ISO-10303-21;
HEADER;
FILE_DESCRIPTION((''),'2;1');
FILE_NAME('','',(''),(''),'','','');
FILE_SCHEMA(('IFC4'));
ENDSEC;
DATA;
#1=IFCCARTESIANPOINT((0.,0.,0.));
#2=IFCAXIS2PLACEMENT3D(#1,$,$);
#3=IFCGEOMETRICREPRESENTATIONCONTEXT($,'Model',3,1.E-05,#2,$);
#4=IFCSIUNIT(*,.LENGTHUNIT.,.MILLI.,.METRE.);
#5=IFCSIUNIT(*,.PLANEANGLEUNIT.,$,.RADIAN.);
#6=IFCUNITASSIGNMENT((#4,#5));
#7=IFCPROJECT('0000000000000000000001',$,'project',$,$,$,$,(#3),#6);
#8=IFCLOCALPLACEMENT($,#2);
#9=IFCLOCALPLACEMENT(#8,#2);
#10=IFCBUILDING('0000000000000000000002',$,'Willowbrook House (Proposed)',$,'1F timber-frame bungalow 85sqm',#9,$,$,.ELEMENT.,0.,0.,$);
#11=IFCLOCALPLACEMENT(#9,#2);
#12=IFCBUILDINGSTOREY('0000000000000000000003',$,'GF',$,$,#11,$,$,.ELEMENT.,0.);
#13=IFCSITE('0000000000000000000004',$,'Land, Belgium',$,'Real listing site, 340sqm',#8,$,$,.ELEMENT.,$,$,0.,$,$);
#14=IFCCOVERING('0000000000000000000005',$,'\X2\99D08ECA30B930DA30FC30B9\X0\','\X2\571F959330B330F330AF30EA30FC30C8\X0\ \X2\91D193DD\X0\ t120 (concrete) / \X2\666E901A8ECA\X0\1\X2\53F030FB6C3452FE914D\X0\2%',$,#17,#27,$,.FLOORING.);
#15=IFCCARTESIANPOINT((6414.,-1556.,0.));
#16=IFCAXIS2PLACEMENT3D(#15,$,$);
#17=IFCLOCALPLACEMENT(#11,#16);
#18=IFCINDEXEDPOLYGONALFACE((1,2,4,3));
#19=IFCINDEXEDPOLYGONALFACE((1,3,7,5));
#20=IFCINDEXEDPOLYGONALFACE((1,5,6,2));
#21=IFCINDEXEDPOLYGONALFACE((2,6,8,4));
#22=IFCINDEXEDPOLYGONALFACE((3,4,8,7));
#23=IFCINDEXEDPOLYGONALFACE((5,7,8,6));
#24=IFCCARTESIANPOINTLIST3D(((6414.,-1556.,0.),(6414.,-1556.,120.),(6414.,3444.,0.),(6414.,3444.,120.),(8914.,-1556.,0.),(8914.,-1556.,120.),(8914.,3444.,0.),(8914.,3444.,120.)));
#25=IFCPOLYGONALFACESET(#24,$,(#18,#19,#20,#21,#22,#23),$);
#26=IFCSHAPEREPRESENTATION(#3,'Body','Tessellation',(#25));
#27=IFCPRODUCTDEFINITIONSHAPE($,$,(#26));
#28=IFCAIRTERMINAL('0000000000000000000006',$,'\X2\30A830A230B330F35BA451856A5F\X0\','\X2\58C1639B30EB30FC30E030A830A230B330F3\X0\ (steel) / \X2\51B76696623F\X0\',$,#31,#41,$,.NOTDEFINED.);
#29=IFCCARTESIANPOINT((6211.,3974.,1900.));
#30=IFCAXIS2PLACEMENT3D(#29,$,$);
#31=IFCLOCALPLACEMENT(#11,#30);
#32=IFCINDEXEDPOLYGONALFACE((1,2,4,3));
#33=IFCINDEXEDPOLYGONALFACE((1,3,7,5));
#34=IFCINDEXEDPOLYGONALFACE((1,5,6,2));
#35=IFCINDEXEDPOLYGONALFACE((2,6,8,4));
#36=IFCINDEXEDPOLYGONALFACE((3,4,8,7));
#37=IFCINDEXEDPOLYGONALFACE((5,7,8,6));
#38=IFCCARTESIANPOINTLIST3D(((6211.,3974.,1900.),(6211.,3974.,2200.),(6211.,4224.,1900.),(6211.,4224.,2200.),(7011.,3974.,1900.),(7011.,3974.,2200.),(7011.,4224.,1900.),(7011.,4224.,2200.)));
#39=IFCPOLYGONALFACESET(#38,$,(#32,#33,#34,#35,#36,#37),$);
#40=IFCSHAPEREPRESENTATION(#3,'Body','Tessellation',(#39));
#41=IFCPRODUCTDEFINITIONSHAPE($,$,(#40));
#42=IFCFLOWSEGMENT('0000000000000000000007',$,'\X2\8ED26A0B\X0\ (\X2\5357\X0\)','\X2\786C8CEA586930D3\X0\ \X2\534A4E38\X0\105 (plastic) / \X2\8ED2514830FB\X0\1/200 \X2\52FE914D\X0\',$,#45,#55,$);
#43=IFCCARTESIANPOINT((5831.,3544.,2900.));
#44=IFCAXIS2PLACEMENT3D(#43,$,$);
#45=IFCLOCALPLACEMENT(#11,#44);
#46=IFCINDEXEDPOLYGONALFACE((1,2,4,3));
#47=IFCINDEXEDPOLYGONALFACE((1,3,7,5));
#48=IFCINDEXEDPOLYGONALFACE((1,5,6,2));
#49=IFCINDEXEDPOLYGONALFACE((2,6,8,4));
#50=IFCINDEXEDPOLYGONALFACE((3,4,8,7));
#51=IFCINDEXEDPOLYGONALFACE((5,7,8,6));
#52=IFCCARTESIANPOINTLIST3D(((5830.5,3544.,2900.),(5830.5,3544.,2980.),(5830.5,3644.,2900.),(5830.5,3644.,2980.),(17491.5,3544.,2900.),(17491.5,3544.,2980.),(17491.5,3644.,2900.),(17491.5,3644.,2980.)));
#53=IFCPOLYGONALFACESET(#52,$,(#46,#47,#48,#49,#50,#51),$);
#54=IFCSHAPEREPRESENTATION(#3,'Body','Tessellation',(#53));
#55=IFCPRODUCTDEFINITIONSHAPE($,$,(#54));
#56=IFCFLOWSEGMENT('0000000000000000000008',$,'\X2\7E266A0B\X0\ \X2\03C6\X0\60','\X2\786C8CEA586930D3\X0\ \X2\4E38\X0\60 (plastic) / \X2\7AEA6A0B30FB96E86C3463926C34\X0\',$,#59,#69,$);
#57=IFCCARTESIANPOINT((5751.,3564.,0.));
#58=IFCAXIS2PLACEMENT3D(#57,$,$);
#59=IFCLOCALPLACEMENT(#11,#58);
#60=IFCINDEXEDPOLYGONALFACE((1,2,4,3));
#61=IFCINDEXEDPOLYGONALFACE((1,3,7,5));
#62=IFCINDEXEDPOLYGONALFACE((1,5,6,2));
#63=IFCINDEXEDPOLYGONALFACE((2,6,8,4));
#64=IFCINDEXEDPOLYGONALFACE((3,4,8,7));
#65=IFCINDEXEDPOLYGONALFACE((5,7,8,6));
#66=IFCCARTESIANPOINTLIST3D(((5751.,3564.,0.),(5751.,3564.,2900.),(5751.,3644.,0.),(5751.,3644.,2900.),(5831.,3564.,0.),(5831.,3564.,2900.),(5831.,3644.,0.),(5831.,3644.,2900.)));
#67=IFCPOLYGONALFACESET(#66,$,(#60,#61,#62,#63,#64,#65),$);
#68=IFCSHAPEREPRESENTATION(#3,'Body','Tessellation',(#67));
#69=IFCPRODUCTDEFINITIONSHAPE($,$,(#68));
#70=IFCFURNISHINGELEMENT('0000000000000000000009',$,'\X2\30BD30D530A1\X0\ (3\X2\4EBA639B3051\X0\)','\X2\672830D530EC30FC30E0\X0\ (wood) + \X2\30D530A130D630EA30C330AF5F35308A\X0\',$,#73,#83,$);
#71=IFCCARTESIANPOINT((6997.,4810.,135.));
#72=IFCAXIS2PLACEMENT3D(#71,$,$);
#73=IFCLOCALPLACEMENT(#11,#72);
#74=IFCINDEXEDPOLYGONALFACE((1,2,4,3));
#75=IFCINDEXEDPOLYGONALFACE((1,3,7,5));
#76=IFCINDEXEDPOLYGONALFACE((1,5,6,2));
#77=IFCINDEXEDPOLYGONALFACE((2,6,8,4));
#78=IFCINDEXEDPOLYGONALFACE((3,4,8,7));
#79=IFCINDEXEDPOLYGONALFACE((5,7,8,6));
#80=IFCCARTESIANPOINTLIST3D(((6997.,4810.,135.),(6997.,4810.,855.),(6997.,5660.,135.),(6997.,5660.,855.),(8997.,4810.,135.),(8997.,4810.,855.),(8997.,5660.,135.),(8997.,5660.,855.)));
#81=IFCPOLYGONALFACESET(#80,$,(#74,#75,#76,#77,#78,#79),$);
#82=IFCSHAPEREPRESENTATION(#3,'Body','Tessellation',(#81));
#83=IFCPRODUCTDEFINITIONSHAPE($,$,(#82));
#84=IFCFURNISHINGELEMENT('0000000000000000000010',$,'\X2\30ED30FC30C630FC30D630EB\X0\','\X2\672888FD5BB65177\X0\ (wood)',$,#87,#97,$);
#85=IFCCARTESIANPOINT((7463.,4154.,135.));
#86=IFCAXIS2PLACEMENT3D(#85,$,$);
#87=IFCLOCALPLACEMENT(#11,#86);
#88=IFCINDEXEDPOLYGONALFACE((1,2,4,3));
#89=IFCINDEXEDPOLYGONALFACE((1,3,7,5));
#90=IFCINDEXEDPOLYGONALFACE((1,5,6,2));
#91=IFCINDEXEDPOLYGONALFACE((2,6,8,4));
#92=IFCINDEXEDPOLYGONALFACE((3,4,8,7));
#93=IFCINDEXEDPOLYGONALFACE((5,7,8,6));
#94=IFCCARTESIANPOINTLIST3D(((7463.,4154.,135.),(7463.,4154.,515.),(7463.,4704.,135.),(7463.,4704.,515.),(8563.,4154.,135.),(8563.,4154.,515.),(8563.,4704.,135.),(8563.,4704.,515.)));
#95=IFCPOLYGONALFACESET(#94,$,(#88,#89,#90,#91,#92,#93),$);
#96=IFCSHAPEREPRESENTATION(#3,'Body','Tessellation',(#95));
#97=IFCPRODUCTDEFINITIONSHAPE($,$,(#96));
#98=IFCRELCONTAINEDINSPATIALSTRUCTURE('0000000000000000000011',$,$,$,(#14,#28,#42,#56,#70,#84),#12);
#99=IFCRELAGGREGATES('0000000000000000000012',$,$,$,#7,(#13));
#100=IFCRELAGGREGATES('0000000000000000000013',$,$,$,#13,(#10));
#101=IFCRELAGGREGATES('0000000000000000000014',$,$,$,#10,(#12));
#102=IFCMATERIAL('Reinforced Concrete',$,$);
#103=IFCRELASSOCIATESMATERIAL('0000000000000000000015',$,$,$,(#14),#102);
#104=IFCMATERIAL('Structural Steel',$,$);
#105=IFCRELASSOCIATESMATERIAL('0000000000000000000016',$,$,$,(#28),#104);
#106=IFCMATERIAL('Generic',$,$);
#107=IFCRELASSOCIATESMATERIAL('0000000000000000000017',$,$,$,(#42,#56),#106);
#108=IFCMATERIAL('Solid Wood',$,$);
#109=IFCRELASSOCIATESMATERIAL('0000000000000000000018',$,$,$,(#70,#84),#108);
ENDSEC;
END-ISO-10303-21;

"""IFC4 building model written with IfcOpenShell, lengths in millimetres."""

from ifc_helpers import new_model, si_unit, frame, frame_2d, origin, place, context, project, spatial, rectangle, extrude, material, element, save


model = new_model("IFC4")

# Units and contexts
model_context = context("Model", 3, precision=1e-05, world=origin())
ifc_project = project(units=[si_unit("LENGTHUNIT", "METRE", prefix="MILLI"), si_unit("PLANEANGLEUNIT", "RADIAN")], contexts=[model_context])

# Site, building, storey
site_placement = place(None, origin())
site = spatial("IfcSite", under=ifc_project, at=site_placement, Name="Land, Belgium", ObjectType="Real listing site, 340sqm", CompositionType="ELEMENT", RefElevation=0.0)
building_placement = place(site_placement, origin())
building = spatial("IfcBuilding", under=site, at=building_placement, Name="Willowbrook House (Proposed)", ObjectType="1F timber-frame bungalow 85sqm", CompositionType="ELEMENT", ElevationOfRefHeight=0.0, ElevationOfTerrain=0.0)
storey_placement = place(building_placement, origin())
storey = spatial("IfcBuildingStorey", under=building, at=storey_placement, Name="GF", CompositionType="ELEMENT", Elevation=0.0)

# Shared definitions
ifc_material_1 = material(Name="Solid Wood")

# Shared definitions
ifc_material_2 = material(Name="Reinforced Concrete")

# Shared definitions
ifc_material_3 = material(Name="Structural Steel")

# Covering
ifc_material_4 = material(Name="Generic")
covering_1_placement = place(storey_placement, frame((6414.0, -1556.0, 0.0)))
element("IfcCovering", 1, at=covering_1_placement, inside=storey, material=ifc_material_2, Name="駐車スペース", Description="土間コンクリート 金鏝 t120 (concrete) / 普通車1台・水勾配2%", PredefinedType="FLOORING", context=model_context, shape_type="SweptSolid", body=[
    extrude(rectangle(XDim=2500.0, YDim=5000.0, at=frame_2d((1250.0, 2500.0))), frame((6414.0, -1556.0, 0.0)), (0.0, 0.0, 1.0), 120.0),
])

# Air terminal
air_terminal_placement = place(storey_placement, frame((6211.0, 3974.0, 1900.0)))
element("IfcAirTerminal", 2, at=air_terminal_placement, inside=storey, material=ifc_material_3, Name="エアコン室内機", Description="壁掛ルームエアコン (steel) / 冷暖房", PredefinedType="NOTDEFINED", context=model_context, shape_type="SweptSolid", body=[
    extrude(rectangle(XDim=800.0, YDim=250.0, at=frame_2d((400.0, 125.0))), frame((6211.0, 3974.0, 1900.0)), (0.0, 0.0, 1.0), 300.0),
])

# Flow segments
flow_segment_1_placement = place(storey_placement, frame((5831.0, 3544.0, 2900.0)))
element("IfcFlowSegment", 3, at=flow_segment_1_placement, inside=storey, material=ifc_material_4, Name="軒樋 (南)", Description="硬質塩ビ 半丸105 (plastic) / 軒先・1/200 勾配", context=model_context, shape_type="SweptSolid", body=[
    extrude(rectangle(XDim=11661.0, YDim=100.0, at=frame_2d((5830.0, 50.0))), frame((5831.0, 3544.0, 2900.0)), (0.0, 0.0, 1.0), 80.0),
])
flow_segment_2_placement = place(storey_placement, frame((5751.0, 3564.0, 0.0)))
element("IfcFlowSegment", 4, at=flow_segment_2_placement, inside=storey, material=ifc_material_4, Name="縦樋 φ60", Description="硬質塩ビ 丸60 (plastic) / 竪樋・雨水排水", context=model_context, shape_type="SweptSolid", body=[
    extrude(rectangle(XDim=80.0, YDim=80.0, at=frame_2d((40.0, 40.0))), frame((5751.0, 3564.0, 0.0)), (0.0, 0.0, 1.0), 2900.0),
])

# Furnishing elements
furnishing_1_placement = place(storey_placement, frame((6997.0, 4810.0, 135.0)))
element("IfcFurnishingElement", 5, at=furnishing_1_placement, inside=storey, material=ifc_material_1, Name="ソファ (3人掛け)", Description="木フレーム (wood) + ファブリック張り", context=model_context, shape_type="SweptSolid", body=[
    extrude(rectangle(XDim=2000.0, YDim=850.0, at=frame_2d((1000.0, 425.0))), frame((6997.0, 4810.0, 135.0)), (0.0, 0.0, 1.0), 720.0),
])
furnishing_2_placement = place(storey_placement, frame((7463.0, 4154.0, 135.0)))
element("IfcFurnishingElement", 6, at=furnishing_2_placement, inside=storey, material=ifc_material_1, Name="ローテーブル", Description="木製家具 (wood)", context=model_context, shape_type="SweptSolid", body=[
    extrude(rectangle(XDim=1100.0, YDim=550.0, at=frame_2d((550.0, 275.0))), frame((7463.0, 4154.0, 135.0)), (0.0, 0.0, 1.0), 380.0),
])

save(model, "model.ifc")
